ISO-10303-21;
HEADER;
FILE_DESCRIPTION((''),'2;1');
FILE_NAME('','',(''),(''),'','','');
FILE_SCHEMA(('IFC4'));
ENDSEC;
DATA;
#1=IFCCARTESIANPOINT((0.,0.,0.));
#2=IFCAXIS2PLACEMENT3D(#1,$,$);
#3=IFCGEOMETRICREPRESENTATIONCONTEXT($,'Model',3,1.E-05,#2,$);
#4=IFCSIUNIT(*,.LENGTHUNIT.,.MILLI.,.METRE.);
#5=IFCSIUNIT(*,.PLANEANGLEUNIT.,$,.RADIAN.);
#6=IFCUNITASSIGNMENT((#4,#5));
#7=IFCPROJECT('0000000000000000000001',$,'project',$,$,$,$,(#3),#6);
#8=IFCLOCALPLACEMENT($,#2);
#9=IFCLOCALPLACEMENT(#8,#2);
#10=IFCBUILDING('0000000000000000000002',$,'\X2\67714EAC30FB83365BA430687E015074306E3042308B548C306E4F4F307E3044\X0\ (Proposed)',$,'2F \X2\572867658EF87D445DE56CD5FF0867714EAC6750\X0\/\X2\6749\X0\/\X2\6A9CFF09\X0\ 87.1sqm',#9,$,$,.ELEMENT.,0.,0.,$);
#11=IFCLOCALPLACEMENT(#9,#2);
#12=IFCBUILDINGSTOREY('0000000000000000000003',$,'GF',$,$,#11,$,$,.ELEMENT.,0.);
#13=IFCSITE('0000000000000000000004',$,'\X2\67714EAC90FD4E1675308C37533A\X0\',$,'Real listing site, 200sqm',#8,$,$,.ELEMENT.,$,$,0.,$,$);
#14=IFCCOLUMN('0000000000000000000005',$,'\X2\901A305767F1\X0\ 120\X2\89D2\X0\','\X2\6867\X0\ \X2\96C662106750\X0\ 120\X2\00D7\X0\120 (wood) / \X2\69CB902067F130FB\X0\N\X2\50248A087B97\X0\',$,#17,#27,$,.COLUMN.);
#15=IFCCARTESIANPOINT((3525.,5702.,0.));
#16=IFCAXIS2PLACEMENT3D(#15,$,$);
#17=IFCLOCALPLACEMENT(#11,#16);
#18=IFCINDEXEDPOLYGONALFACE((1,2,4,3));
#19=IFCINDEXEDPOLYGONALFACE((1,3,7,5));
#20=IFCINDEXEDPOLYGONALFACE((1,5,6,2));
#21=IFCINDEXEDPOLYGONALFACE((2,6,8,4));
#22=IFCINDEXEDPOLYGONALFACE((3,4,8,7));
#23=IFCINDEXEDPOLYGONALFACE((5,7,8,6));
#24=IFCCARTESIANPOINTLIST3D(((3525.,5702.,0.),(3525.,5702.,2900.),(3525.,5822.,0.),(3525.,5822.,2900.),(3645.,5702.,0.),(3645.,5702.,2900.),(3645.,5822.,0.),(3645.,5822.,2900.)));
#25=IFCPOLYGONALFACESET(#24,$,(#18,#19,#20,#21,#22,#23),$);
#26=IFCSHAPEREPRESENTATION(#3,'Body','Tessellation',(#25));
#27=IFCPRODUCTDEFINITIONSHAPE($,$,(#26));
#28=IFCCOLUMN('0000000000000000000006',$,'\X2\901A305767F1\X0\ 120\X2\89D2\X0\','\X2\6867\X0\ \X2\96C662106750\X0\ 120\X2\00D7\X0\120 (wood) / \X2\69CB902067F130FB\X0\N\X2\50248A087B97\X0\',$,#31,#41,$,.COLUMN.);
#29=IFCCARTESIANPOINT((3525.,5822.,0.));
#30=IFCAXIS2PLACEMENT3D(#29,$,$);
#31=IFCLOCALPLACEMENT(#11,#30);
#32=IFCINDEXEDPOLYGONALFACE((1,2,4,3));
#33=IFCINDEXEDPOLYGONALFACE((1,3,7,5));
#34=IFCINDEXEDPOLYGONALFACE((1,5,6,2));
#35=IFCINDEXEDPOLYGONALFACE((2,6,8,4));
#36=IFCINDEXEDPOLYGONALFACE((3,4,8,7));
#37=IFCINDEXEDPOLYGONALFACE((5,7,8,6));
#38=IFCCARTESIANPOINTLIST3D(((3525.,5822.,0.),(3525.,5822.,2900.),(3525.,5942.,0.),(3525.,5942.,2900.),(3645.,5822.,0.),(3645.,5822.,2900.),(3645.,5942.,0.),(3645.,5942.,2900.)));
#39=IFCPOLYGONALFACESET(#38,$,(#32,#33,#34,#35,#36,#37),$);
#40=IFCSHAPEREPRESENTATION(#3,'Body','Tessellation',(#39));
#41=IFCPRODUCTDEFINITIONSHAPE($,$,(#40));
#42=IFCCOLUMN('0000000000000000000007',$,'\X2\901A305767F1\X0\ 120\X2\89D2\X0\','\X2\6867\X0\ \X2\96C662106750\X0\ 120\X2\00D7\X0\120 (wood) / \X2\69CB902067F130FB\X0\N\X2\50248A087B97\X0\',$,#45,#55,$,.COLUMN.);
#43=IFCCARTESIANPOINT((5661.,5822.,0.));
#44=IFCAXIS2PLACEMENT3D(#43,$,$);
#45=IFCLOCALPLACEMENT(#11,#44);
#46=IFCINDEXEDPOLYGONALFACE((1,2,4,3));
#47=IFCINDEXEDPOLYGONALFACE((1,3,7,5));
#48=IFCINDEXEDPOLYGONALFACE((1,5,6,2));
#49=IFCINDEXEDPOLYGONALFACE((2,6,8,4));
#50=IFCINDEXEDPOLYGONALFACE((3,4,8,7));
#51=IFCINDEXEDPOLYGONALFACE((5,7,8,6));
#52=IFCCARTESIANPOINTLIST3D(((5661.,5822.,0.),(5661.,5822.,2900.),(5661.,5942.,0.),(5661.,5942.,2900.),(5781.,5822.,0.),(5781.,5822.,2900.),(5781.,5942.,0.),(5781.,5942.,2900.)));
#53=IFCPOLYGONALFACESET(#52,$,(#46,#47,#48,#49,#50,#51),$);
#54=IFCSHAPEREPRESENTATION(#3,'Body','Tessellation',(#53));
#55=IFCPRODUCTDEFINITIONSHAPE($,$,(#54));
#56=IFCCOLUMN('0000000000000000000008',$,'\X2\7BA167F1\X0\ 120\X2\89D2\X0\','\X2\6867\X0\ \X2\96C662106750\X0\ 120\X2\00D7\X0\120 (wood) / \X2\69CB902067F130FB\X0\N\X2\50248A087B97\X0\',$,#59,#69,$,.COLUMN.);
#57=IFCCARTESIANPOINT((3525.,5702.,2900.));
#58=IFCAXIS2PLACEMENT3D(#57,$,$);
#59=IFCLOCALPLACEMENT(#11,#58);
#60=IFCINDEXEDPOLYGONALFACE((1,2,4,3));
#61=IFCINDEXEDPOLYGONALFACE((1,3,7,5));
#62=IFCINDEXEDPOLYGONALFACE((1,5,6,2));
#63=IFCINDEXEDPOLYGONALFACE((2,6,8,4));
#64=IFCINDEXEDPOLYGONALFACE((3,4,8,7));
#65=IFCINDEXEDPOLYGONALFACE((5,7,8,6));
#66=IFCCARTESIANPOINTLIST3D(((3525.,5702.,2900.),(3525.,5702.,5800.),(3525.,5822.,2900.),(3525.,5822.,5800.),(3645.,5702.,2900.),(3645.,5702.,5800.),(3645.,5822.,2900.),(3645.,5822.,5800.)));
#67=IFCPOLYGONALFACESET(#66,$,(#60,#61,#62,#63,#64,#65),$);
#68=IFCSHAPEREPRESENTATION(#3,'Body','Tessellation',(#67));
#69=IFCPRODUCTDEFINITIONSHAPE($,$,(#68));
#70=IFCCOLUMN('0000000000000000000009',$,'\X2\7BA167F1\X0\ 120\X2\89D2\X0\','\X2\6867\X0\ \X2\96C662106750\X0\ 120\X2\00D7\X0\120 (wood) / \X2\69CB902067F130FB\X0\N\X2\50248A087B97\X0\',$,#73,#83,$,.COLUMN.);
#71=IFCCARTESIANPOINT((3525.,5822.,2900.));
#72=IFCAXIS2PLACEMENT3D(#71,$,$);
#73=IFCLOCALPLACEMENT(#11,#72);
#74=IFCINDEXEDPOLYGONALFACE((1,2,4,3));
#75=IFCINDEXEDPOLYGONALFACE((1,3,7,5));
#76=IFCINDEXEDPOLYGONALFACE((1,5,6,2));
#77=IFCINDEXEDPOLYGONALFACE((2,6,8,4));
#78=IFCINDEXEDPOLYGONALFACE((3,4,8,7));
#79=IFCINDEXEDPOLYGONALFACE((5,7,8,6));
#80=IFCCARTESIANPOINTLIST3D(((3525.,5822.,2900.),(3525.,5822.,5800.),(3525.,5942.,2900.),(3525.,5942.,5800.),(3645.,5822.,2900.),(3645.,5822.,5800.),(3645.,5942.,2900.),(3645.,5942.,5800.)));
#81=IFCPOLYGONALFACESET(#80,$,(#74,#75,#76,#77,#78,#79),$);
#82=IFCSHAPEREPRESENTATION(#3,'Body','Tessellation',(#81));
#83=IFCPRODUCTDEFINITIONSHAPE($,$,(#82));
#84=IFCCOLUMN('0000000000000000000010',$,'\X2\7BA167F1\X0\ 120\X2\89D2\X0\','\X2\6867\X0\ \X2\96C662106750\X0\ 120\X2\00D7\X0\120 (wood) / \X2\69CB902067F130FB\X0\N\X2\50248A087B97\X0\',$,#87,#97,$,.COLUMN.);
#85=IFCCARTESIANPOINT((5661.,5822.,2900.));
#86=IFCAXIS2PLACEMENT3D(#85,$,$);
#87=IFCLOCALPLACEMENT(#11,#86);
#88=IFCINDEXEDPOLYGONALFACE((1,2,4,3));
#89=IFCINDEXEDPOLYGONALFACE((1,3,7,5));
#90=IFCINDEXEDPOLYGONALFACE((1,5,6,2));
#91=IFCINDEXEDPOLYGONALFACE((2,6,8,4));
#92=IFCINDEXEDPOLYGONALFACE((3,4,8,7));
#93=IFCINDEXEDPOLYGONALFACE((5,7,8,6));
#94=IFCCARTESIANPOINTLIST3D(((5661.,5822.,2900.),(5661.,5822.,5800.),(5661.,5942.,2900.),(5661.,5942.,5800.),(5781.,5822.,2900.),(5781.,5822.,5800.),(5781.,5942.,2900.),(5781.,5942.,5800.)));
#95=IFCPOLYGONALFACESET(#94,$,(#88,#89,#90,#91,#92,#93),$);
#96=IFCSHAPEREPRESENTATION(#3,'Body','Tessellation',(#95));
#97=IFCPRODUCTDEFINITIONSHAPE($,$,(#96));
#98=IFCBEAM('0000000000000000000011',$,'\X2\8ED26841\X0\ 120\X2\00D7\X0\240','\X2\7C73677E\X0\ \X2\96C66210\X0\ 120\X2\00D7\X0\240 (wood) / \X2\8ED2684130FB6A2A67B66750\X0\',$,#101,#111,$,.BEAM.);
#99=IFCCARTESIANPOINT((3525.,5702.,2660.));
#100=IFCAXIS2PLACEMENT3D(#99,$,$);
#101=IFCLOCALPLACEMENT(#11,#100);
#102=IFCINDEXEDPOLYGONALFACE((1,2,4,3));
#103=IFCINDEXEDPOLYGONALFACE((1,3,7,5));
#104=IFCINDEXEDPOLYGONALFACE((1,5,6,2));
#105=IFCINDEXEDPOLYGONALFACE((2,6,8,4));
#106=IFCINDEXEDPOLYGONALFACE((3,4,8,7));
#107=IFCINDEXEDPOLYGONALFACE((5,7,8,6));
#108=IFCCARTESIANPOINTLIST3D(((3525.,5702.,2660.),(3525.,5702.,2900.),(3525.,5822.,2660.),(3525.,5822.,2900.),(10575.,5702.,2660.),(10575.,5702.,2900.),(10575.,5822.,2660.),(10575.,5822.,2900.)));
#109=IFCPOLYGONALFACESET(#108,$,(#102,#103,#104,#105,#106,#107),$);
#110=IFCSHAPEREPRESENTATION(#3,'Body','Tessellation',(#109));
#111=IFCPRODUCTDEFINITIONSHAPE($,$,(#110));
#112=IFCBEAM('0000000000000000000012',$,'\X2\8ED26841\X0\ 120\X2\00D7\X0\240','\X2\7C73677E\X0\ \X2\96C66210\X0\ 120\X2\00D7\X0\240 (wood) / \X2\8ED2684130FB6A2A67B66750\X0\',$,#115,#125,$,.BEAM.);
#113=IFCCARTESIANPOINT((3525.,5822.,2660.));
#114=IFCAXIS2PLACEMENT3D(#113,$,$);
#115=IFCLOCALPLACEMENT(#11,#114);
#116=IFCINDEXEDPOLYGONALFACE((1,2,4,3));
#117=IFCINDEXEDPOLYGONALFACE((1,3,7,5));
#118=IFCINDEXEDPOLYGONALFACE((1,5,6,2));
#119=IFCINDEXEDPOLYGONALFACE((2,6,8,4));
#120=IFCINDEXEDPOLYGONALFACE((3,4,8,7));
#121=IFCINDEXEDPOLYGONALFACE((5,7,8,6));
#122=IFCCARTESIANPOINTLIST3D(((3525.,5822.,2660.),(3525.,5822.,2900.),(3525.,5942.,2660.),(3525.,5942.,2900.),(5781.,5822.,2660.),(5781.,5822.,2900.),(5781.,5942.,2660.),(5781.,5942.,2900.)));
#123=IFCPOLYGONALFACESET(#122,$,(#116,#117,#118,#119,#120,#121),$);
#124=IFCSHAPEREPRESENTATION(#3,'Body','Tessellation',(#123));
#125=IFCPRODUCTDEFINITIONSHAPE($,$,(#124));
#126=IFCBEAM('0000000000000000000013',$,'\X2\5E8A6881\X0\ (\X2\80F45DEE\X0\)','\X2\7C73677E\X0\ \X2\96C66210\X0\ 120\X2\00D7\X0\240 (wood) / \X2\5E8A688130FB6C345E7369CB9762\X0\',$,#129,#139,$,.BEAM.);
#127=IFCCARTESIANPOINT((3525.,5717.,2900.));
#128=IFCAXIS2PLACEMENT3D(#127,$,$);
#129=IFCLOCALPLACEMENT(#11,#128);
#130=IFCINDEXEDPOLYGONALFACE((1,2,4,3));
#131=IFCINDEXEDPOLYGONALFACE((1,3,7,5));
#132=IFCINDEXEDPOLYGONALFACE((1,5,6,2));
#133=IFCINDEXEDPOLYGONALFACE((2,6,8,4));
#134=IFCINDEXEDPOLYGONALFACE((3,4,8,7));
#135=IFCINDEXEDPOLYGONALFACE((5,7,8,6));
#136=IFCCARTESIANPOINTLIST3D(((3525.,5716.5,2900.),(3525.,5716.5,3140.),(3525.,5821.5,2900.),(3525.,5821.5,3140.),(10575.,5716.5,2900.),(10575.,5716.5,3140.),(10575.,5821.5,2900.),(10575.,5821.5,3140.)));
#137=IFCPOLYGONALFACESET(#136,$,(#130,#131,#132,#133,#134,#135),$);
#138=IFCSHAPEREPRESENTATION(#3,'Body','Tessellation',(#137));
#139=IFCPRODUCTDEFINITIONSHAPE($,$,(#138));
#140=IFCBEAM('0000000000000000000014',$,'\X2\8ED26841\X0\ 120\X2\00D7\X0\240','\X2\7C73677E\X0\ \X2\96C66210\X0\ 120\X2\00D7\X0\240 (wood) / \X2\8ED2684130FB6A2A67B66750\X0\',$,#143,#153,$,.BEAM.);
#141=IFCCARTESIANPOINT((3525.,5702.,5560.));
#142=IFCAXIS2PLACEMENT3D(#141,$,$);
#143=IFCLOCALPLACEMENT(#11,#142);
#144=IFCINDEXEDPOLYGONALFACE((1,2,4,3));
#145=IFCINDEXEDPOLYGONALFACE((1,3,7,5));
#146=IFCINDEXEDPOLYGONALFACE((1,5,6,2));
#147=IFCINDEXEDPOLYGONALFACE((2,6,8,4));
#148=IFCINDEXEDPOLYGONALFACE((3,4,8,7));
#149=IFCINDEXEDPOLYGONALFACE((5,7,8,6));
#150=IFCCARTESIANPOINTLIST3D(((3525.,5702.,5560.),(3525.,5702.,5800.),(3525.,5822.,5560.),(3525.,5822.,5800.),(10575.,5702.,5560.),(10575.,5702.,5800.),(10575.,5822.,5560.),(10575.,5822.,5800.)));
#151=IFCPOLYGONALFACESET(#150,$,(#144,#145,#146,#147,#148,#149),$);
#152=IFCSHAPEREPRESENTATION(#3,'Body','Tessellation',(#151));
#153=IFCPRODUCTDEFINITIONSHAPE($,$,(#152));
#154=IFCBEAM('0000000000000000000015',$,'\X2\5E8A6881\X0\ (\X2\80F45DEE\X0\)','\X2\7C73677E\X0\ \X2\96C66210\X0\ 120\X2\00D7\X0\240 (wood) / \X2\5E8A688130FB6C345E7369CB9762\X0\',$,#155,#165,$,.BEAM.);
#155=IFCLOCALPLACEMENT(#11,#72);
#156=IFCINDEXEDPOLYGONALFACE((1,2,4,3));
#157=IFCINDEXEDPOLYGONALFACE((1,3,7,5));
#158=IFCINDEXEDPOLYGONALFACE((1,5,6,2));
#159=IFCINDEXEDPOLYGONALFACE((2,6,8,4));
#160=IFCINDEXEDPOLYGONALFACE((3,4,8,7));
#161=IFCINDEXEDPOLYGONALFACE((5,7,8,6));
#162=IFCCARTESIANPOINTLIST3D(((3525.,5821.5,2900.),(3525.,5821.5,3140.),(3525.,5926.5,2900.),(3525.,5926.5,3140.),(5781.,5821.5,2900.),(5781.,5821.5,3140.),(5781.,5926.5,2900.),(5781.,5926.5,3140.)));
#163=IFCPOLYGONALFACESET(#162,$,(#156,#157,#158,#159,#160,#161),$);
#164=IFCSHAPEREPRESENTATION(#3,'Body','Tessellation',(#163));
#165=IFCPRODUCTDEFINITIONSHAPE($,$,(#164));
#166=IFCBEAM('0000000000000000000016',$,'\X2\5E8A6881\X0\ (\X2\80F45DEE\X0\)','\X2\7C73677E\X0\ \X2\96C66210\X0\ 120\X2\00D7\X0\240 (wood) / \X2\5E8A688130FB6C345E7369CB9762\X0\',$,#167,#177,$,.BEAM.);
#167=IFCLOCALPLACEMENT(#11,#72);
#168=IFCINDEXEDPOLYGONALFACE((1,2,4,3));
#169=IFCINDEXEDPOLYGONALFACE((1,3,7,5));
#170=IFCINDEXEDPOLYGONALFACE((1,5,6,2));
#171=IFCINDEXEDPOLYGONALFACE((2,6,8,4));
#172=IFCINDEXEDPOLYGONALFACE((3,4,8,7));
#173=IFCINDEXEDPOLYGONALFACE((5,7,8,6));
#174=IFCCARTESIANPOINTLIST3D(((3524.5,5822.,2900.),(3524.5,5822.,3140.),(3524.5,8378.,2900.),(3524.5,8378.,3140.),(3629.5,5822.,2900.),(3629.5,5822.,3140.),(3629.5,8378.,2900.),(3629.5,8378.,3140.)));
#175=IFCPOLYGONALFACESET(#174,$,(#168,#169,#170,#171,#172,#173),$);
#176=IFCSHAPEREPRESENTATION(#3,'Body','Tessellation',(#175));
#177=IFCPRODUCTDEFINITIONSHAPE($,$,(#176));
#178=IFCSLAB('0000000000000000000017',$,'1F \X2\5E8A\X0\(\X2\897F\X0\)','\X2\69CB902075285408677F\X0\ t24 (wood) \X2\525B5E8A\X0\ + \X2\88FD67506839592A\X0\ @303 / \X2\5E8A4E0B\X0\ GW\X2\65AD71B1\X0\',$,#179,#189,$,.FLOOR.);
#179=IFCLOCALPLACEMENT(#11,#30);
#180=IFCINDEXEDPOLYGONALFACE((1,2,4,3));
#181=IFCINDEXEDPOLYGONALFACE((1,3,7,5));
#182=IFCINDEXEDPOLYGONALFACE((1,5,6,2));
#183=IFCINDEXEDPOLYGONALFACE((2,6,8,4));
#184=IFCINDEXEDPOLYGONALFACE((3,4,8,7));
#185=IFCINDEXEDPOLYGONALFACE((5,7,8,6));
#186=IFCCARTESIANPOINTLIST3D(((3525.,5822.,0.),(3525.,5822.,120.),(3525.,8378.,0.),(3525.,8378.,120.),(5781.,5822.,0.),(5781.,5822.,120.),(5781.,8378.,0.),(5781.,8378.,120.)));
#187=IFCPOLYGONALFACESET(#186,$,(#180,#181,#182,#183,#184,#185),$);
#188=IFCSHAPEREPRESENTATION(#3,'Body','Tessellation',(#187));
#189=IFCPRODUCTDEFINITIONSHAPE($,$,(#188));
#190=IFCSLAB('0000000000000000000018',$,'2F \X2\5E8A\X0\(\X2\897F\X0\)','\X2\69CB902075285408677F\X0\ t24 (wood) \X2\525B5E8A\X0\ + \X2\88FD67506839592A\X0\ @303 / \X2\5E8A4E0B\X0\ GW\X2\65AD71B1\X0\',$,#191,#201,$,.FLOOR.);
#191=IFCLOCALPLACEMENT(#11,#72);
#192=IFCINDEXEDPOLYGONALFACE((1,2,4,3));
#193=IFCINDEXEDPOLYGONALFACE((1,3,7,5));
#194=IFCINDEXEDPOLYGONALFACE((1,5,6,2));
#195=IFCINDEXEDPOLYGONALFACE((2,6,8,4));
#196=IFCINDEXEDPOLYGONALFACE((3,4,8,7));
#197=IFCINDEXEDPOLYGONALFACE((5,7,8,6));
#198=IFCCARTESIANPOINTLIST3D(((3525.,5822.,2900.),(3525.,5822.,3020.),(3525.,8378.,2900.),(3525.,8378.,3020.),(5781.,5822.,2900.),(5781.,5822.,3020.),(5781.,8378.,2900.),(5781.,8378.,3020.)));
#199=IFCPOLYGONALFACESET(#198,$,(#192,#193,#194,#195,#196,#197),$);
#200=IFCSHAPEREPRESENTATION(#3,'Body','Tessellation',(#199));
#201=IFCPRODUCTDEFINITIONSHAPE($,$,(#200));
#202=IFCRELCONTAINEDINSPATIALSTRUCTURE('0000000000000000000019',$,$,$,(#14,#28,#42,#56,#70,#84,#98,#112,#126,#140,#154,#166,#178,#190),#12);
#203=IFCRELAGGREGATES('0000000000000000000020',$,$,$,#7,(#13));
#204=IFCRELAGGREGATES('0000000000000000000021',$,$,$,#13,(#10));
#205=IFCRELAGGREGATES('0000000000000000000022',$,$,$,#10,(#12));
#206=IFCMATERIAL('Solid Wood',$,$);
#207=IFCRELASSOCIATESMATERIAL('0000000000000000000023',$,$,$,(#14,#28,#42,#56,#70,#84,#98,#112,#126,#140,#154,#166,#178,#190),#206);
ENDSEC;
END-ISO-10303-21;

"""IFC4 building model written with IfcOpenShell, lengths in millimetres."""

from ifc_helpers import new_model, si_unit, frame, frame_2d, origin, place, context, project, spatial, rectangle, extrude, material, element, save


model = new_model("IFC4")

# Units and contexts
model_context = context("Model", 3, precision=1e-05, world=origin())
ifc_project = project(units=[si_unit("LENGTHUNIT", "METRE", prefix="MILLI"), si_unit("PLANEANGLEUNIT", "RADIAN")], contexts=[model_context])

# Site, building, storey
site_placement = place(None, origin())
site = spatial("IfcSite", under=ifc_project, at=site_placement, Name="東京都世田谷区", ObjectType="Real listing site, 200sqm", CompositionType="ELEMENT", RefElevation=0.0)
building_placement = place(site_placement, origin())
building = spatial("IfcBuilding", under=site, at=building_placement, Name="東京・茶室と縁側のある和の住まい (Proposed)", ObjectType="2F 在来軸組工法（東京材/杉/檜） 87.1sqm", CompositionType="ELEMENT", ElevationOfRefHeight=0.0, ElevationOfTerrain=0.0)
storey_placement = place(building_placement, origin())
storey = spatial("IfcBuildingStorey", under=building, at=storey_placement, Name="GF", CompositionType="ELEMENT", Elevation=0.0)

# Columns
ifc_material_1 = material(Name="Solid Wood")
column_1_placement = place(storey_placement, frame((3525.0, 5702.0, 0.0)))
element("IfcColumn", 1, at=column_1_placement, inside=storey, material=ifc_material_1, Name="通し柱 120角", Description="桧 集成材 120×120 (wood) / 構造柱・N値計算", PredefinedType="COLUMN", context=model_context, shape_type="SweptSolid", body=[
    extrude(rectangle(XDim=120.0, YDim=120.0, at=frame_2d((60.0, 60.0))), frame((3525.0, 5702.0, 0.0)), (0.0, 0.0, 1.0), 2900.0),
])
column_2_placement = place(storey_placement, frame((3525.0, 5822.0, 0.0)))
element("IfcColumn", 2, at=column_2_placement, inside=storey, material=ifc_material_1, Name="通し柱 120角", Description="桧 集成材 120×120 (wood) / 構造柱・N値計算", PredefinedType="COLUMN", context=model_context, shape_type="SweptSolid", body=[
    extrude(rectangle(XDim=120.0, YDim=120.0, at=frame_2d((60.0, 60.0))), frame((3525.0, 5822.0, 0.0)), (0.0, 0.0, 1.0), 2900.0),
])
column_3_placement = place(storey_placement, frame((5661.0, 5822.0, 0.0)))
element("IfcColumn", 3, at=column_3_placement, inside=storey, material=ifc_material_1, Name="通し柱 120角", Description="桧 集成材 120×120 (wood) / 構造柱・N値計算", PredefinedType="COLUMN", context=model_context, shape_type="SweptSolid", body=[
    extrude(rectangle(XDim=120.0, YDim=120.0, at=frame_2d((60.0, 60.0))), frame((5661.0, 5822.0, 0.0)), (0.0, 0.0, 1.0), 2900.0),
])
column_4_placement = place(storey_placement, frame((3525.0, 5702.0, 2900.0)))
element("IfcColumn", 4, at=column_4_placement, inside=storey, material=ifc_material_1, Name="管柱 120角", Description="桧 集成材 120×120 (wood) / 構造柱・N値計算", PredefinedType="COLUMN", context=model_context, shape_type="SweptSolid", body=[
    extrude(rectangle(XDim=120.0, YDim=120.0, at=frame_2d((60.0, 60.0))), frame((3525.0, 5702.0, 2900.0)), (0.0, 0.0, 1.0), 2900.0),
])
column_5_placement = place(storey_placement, frame((3525.0, 5822.0, 2900.0)))
element("IfcColumn", 5, at=column_5_placement, inside=storey, material=ifc_material_1, Name="管柱 120角", Description="桧 集成材 120×120 (wood) / 構造柱・N値計算", PredefinedType="COLUMN", context=model_context, shape_type="SweptSolid", body=[
    extrude(rectangle(XDim=120.0, YDim=120.0, at=frame_2d((60.0, 60.0))), frame((3525.0, 5822.0, 2900.0)), (0.0, 0.0, 1.0), 2900.0),
])
column_6_placement = place(storey_placement, frame((5661.0, 5822.0, 2900.0)))
element("IfcColumn", 6, at=column_6_placement, inside=storey, material=ifc_material_1, Name="管柱 120角", Description="桧 集成材 120×120 (wood) / 構造柱・N値計算", PredefinedType="COLUMN", context=model_context, shape_type="SweptSolid", body=[
    extrude(rectangle(XDim=120.0, YDim=120.0, at=frame_2d((60.0, 60.0))), frame((5661.0, 5822.0, 2900.0)), (0.0, 0.0, 1.0), 2900.0),
])

# Beams
beam_1_placement = place(storey_placement, frame((3525.0, 5702.0, 2660.0)))
element("IfcBeam", 7, at=beam_1_placement, inside=storey, material=ifc_material_1, Name="軒桁 120×240", Description="米松 集成 120×240 (wood) / 軒桁・横架材", PredefinedType="BEAM", context=model_context, shape_type="SweptSolid", body=[
    extrude(rectangle(XDim=7050.0, YDim=120.0, at=frame_2d((3525.0, 60.0))), frame((3525.0, 5702.0, 2660.0)), (0.0, 0.0, 1.0), 240.0),
])
beam_2_placement = place(storey_placement, frame((3525.0, 5822.0, 2660.0)))
element("IfcBeam", 8, at=beam_2_placement, inside=storey, material=ifc_material_1, Name="軒桁 120×240", Description="米松 集成 120×240 (wood) / 軒桁・横架材", PredefinedType="BEAM", context=model_context, shape_type="SweptSolid", body=[
    extrude(rectangle(XDim=2256.0, YDim=120.0, at=frame_2d((1128.0, 60.0))), frame((3525.0, 5822.0, 2660.0)), (0.0, 0.0, 1.0), 240.0),
])
beam_3_placement = place(storey_placement, frame((3525.0, 5717.0, 2900.0)))
element("IfcBeam", 9, at=beam_3_placement, inside=storey, material=ifc_material_1, Name="床梁 (胴差)", Description="米松 集成 120×240 (wood) / 床梁・水平構面", PredefinedType="BEAM", context=model_context, shape_type="SweptSolid", body=[
    extrude(rectangle(XDim=7050.0, YDim=105.0, at=frame_2d((3525.0, 52.0))), frame((3525.0, 5717.0, 2900.0)), (0.0, 0.0, 1.0), 240.0),
])
beam_4_placement = place(storey_placement, frame((3525.0, 5702.0, 5560.0)))
element("IfcBeam", 10, at=beam_4_placement, inside=storey, material=ifc_material_1, Name="軒桁 120×240", Description="米松 集成 120×240 (wood) / 軒桁・横架材", PredefinedType="BEAM", context=model_context, shape_type="SweptSolid", body=[
    extrude(rectangle(XDim=7050.0, YDim=120.0, at=frame_2d((3525.0, 60.0))), frame((3525.0, 5702.0, 5560.0)), (0.0, 0.0, 1.0), 240.0),
])
beam_5_placement = place(storey_placement, frame((3525.0, 5822.0, 2900.0)))
element("IfcBeam", 11, at=beam_5_placement, inside=storey, material=ifc_material_1, Name="床梁 (胴差)", Description="米松 集成 120×240 (wood) / 床梁・水平構面", PredefinedType="BEAM", context=model_context, shape_type="SweptSolid", body=[
    extrude(rectangle(XDim=2256.0, YDim=105.0, at=frame_2d((1128.0, 52.0))), frame((3525.0, 5822.0, 2900.0)), (0.0, 0.0, 1.0), 240.0),
])
beam_6_placement = place(storey_placement, frame((3525.0, 5822.0, 2900.0)))
element("IfcBeam", 12, at=beam_6_placement, inside=storey, material=ifc_material_1, Name="床梁 (胴差)", Description="米松 集成 120×240 (wood) / 床梁・水平構面", PredefinedType="BEAM", context=model_context, shape_type="SweptSolid", body=[
    extrude(rectangle(XDim=105.0, YDim=2556.0, at=frame_2d((52.0, 1278.0))), frame((3525.0, 5822.0, 2900.0)), (0.0, 0.0, 1.0), 240.0),
])

# Slabs
slab_1_placement = place(storey_placement, frame((3525.0, 5822.0, 0.0)))
element("IfcSlab", 13, at=slab_1_placement, inside=storey, material=ifc_material_1, Name="1F 床(西)", Description="構造用合板 t24 (wood) 剛床 + 製材根太 @303 / 床下 GW断熱", PredefinedType="FLOOR", context=model_context, shape_type="SweptSolid", body=[
    extrude(rectangle(XDim=2256.0, YDim=2556.0, at=frame_2d((1128.0, 1278.0))), frame((3525.0, 5822.0, 0.0)), (0.0, 0.0, 1.0), 120.0),
])
slab_2_placement = place(storey_placement, frame((3525.0, 5822.0, 2900.0)))
element("IfcSlab", 14, at=slab_2_placement, inside=storey, material=ifc_material_1, Name="2F 床(西)", Description="構造用合板 t24 (wood) 剛床 + 製材根太 @303 / 床下 GW断熱", PredefinedType="FLOOR", context=model_context, shape_type="SweptSolid", body=[
    extrude(rectangle(XDim=2256.0, YDim=2556.0, at=frame_2d((1128.0, 1278.0))), frame((3525.0, 5822.0, 2900.0)), (0.0, 0.0, 1.0), 120.0),
])

save(model, "model.ifc")
